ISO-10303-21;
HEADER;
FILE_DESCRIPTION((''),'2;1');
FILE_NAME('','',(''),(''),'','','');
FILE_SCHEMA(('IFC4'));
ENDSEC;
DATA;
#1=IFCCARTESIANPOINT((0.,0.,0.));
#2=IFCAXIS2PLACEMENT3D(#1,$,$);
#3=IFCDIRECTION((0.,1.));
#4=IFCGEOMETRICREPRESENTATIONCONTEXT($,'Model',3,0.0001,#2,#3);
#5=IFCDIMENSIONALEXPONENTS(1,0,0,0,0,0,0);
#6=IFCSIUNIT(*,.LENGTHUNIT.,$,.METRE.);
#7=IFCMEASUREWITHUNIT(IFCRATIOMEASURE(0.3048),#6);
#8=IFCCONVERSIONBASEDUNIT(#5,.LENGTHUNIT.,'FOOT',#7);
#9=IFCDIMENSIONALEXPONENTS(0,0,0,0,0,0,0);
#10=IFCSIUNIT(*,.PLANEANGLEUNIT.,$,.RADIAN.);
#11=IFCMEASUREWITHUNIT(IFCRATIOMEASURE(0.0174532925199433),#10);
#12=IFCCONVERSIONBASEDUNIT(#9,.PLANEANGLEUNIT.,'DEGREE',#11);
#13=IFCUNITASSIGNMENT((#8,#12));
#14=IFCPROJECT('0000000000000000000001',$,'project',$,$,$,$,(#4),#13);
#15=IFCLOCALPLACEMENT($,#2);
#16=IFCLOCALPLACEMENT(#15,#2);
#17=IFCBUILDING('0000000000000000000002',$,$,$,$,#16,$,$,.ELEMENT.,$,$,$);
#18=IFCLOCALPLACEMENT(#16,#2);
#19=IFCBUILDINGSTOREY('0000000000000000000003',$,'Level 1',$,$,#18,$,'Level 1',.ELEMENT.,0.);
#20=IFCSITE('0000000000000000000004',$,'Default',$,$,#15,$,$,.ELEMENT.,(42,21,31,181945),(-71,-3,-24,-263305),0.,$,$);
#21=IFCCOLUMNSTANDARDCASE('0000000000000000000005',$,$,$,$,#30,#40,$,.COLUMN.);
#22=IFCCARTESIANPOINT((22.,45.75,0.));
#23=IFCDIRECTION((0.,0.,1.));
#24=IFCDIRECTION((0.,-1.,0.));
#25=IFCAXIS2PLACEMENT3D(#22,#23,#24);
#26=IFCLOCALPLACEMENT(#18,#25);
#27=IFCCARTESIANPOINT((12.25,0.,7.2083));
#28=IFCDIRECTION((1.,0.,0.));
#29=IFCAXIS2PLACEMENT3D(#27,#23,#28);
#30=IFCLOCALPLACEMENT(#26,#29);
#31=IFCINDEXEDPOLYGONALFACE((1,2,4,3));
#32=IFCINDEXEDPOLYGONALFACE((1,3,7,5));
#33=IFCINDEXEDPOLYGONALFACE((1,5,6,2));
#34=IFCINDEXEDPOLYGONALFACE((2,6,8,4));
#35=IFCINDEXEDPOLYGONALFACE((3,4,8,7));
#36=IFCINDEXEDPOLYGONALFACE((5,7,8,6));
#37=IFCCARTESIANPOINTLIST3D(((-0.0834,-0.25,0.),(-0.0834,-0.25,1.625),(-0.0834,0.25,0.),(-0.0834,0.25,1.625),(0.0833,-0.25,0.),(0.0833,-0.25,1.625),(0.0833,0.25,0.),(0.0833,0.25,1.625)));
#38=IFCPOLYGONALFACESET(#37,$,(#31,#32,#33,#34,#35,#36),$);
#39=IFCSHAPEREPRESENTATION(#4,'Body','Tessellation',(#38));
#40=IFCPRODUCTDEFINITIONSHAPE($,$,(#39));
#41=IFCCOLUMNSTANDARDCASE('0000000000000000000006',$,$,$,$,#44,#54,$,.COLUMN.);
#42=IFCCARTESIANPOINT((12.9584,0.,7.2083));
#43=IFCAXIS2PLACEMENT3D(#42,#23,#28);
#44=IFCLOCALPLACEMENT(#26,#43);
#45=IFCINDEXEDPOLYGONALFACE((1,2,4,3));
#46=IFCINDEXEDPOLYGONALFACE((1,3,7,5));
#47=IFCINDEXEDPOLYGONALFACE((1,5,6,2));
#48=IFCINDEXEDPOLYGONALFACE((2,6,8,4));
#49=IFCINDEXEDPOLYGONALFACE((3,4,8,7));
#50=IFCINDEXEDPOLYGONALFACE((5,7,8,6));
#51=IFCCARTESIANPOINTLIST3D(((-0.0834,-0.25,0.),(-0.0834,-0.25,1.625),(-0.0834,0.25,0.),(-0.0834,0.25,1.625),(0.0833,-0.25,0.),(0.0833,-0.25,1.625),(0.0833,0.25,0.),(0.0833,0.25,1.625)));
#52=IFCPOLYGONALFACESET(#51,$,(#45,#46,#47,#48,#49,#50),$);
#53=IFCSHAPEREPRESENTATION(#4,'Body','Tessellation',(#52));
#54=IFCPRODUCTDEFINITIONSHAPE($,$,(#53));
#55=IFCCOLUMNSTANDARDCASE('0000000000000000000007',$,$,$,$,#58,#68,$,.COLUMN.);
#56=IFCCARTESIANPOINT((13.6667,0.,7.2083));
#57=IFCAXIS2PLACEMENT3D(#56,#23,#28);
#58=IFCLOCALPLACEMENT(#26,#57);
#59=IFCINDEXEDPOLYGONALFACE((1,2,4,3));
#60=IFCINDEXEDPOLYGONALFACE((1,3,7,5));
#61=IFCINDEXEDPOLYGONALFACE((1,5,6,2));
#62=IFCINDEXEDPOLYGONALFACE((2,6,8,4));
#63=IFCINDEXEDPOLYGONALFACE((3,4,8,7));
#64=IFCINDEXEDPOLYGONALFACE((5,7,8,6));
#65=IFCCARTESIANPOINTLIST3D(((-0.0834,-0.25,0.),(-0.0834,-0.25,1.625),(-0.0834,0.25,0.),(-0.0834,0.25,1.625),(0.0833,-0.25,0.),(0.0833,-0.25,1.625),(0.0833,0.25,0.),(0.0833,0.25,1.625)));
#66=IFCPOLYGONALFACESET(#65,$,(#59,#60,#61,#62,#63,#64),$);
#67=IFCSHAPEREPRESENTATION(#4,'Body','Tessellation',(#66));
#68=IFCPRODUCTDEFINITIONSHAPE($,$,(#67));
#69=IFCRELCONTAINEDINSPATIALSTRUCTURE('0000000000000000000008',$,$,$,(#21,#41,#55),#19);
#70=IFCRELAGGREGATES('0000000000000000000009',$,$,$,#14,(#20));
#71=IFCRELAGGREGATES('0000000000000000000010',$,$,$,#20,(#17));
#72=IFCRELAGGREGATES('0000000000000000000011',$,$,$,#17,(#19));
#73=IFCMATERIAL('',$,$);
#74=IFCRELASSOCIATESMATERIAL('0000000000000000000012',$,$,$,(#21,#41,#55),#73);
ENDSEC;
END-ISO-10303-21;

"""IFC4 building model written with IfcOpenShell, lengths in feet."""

from ifc_helpers import new_model, entity, si_unit, converted_unit, direction, frame, origin, place, context, project, spatial, rectangle, extrude, material, element, save


model = new_model("IFC4")

# Units and contexts
model_context = context("Model", 3, precision=0.0001, world=origin(), true_north=direction((0.0, 1.0)))
ifc_project = project(units=[converted_unit("LENGTHUNIT", "FOOT", entity("IfcRatioMeasure", 0.3048), si_unit("LENGTHUNIT", "METRE"), dimensions=[1, 0, 0, 0, 0, 0, 0]), converted_unit("PLANEANGLEUNIT", "DEGREE", entity("IfcRatioMeasure", 0.0174532925199433), si_unit("PLANEANGLEUNIT", "RADIAN"), dimensions=[0, 0, 0, 0, 0, 0, 0])], contexts=[model_context])

# Site, building, storey
site_placement = place(None, origin())
site = spatial("IfcSite", under=ifc_project, at=site_placement, Name="Default", CompositionType="ELEMENT", RefLatitude=(42, 21, 31, 181945), RefLongitude=(-71, -3, -24, -263305), RefElevation=0.0)
building_placement = place(site_placement, origin())
building = spatial("IfcBuilding", under=site, at=building_placement, CompositionType="ELEMENT")
storey_placement = place(building_placement, origin())
storey = spatial("IfcBuildingStorey", under=building, at=storey_placement, Name="Level 1", LongName="Level 1", CompositionType="ELEMENT", Elevation=0.0)

# Columns
placement = place(storey_placement, frame((22.0, 45.75, 0.0), z_axis=(0.0, 0.0, 1.0), x_axis=(0.0, -1.0, 0.0)))
ifc_material_1 = material(Name="")
for number, where, z_axis, x_axis in (
    (1, (12.25, 0.0, 7.2083), (0.0, 0.0, 1.0), (1.0, 0.0, 0.0)),
    (2, (12.9584, 0.0, 7.2083), (0.0, 0.0, 1.0), (1.0, 0.0, 0.0)),
    (3, (13.6667, 0.0, 7.2083), (0.0, 0.0, 1.0), (1.0, 0.0, 0.0)),
):
    element("IfcColumnStandardCase", number, at=place(placement, frame(where, z_axis=z_axis, x_axis=x_axis)), inside=storey, material=ifc_material_1, PredefinedType="COLUMN", context=model_context, shape_type="SweptSolid", body=[
        extrude(rectangle(XDim=0.1667, YDim=0.5), origin(), (0.0, 0.0, 1.0), 1.625),
    ])

save(model, "model.ifc")
